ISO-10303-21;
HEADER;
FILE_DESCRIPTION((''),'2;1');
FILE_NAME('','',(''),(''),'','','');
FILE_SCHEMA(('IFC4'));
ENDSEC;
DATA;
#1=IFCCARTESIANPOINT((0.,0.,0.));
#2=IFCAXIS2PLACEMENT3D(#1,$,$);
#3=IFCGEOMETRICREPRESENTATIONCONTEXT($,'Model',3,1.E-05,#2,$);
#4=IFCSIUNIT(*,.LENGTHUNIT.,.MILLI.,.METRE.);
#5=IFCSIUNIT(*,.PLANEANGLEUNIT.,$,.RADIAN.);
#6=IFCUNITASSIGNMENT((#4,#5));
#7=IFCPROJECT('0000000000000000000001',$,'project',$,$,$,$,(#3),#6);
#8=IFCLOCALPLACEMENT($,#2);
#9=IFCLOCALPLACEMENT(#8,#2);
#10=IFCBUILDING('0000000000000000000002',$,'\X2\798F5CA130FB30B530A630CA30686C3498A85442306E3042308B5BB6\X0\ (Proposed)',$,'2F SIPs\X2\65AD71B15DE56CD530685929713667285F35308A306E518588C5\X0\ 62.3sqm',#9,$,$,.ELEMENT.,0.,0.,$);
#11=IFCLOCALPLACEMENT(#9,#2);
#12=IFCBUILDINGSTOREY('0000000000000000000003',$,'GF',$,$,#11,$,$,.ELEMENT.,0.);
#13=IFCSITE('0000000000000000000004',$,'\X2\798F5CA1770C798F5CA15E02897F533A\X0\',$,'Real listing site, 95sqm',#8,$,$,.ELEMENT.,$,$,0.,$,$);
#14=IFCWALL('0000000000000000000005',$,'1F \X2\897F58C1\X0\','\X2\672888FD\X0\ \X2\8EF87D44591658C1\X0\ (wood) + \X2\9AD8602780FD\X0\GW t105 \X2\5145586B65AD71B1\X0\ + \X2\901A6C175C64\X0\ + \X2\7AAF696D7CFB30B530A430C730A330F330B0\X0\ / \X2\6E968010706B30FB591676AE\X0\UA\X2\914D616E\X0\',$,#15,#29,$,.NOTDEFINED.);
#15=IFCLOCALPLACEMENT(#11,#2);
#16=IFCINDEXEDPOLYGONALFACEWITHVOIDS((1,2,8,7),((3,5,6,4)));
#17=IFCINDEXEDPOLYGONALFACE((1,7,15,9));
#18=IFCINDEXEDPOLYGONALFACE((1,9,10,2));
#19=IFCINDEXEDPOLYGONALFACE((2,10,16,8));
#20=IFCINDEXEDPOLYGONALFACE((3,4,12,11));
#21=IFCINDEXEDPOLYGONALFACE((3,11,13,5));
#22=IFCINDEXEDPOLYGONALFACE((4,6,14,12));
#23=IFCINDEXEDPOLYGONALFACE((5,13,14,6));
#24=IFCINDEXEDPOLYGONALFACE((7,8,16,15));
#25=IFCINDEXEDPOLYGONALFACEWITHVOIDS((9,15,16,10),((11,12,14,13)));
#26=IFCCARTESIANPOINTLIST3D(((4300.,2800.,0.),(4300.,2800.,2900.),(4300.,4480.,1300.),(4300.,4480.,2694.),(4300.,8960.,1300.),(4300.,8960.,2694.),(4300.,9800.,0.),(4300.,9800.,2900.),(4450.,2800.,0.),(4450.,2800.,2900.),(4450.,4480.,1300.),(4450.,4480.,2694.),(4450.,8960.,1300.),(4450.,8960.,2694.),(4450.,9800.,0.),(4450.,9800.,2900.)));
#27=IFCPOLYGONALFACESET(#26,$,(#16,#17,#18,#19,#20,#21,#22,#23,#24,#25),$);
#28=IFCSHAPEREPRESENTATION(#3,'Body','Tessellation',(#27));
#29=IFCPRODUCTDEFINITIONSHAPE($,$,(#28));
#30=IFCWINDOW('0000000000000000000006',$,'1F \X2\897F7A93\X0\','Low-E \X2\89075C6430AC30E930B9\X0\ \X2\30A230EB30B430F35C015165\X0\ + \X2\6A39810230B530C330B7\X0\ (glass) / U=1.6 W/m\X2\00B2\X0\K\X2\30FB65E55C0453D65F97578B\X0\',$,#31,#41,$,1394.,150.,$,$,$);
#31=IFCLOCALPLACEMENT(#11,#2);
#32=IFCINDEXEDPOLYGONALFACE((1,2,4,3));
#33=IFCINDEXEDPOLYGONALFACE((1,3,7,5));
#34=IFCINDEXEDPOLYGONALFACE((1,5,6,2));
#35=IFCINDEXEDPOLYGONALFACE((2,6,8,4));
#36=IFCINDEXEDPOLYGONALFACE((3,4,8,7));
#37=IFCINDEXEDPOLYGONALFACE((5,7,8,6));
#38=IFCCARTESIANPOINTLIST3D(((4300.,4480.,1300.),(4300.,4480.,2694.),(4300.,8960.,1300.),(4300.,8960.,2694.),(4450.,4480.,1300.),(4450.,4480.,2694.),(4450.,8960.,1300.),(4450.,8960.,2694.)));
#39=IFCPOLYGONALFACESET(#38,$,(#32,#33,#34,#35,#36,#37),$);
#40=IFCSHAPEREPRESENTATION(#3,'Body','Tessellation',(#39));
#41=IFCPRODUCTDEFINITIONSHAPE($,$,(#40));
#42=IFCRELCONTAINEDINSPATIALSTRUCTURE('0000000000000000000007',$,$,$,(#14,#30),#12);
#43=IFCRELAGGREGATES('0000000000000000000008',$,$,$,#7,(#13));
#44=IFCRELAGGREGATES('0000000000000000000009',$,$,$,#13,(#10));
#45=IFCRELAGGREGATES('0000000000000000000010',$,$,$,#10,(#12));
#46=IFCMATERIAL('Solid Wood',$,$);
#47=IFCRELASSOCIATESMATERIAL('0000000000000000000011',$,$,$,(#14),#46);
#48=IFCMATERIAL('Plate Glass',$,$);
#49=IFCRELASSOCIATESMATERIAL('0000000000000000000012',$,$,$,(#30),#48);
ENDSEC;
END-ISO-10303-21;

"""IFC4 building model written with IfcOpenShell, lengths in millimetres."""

from ifc_helpers import new_model, si_unit, frame, frame_2d, origin, place, context, project, spatial, rectangle, extrude, material, element, fill, save


model = new_model("IFC4")

# Units and contexts
model_context = context("Model", 3, precision=1e-05, world=origin())
ifc_project = project(units=[si_unit("LENGTHUNIT", "METRE", prefix="MILLI"), si_unit("PLANEANGLEUNIT", "RADIAN")], contexts=[model_context])

# Site, building, storey
site_placement = place(None, origin())
site = spatial("IfcSite", under=ifc_project, at=site_placement, Name="福岡県福岡市西区", ObjectType="Real listing site, 95sqm", CompositionType="ELEMENT", RefElevation=0.0)
building_placement = place(site_placement, origin())
building = spatial("IfcBuilding", under=site, at=building_placement, Name="福岡・サウナと水風呂のある家 (Proposed)", ObjectType="2F SIPs断熱工法と天然木張りの内装 62.3sqm", CompositionType="ELEMENT", ElevationOfRefHeight=0.0, ElevationOfTerrain=0.0)
storey_placement = place(building_placement, origin())
storey = spatial("IfcBuildingStorey", under=building, at=storey_placement, Name="GF", CompositionType="ELEMENT", Elevation=0.0)

# Shared definitions
ifc_material_1 = material(Name="Solid Wood")

# Shared definitions
ifc_material_2 = material(Name="Plate Glass")

# Wall, opening, window
wall_1_placement = place(storey_placement, frame((2150.0, 1400.0, 0.0)))
wall_1 = element("IfcWall", 1, at=wall_1_placement, inside=storey, material=ifc_material_1, Name="1F 西壁", Description="木製 軸組外壁 (wood) + 高性能GW t105 充填断熱 + 通気層 + 窯業系サイディング / 準耐火・外皮UA配慮", PredefinedType="NOTDEFINED", context=model_context, shape_type="SweptSolid", body=[
    extrude(rectangle(XDim=150.0, YDim=7000.0, at=frame_2d((75.0, 3500.0))), frame((2150.0, 1400.0, 0.0)), (0.0, 0.0, 1.0), 2900.0),
])
opening_1_placement = place(storey_placement, frame((2150.0, 2240.0, 650.0)))
opening_1 = element("IfcOpeningElement", 2, at=opening_1_placement, cuts=wall_1, PredefinedType="NOTDEFINED", context=model_context, shape_type="SweptSolid", body=[
    extrude(rectangle(XDim=150.0, YDim=4480.0, at=frame_2d((75.0, 2240.0))), frame((2150.0, 2240.0, 650.0)), (0.0, 0.0, 1.0), 1394.0),
])
window_1_placement = place(storey_placement, frame((2150.0, 2240.0, 650.0)))
window_1 = element("IfcWindow", 3, at=window_1_placement, inside=storey, material=ifc_material_2, Name="1F 西窓", Description="Low-E 複層ガラス アルゴン封入 + 樹脂サッシ (glass) / U=1.6 W/m²K・日射取得型", OverallHeight=1394.0, OverallWidth=150.0, context=model_context, shape_type="SweptSolid", body=[
    extrude(rectangle(XDim=150.0, YDim=4480.0, at=frame_2d((75.0, 2240.0))), frame((2150.0, 2240.0, 650.0)), (0.0, 0.0, 1.0), 1394.0),
])
fill(opening_1, window_1)

save(model, "model.ifc")
